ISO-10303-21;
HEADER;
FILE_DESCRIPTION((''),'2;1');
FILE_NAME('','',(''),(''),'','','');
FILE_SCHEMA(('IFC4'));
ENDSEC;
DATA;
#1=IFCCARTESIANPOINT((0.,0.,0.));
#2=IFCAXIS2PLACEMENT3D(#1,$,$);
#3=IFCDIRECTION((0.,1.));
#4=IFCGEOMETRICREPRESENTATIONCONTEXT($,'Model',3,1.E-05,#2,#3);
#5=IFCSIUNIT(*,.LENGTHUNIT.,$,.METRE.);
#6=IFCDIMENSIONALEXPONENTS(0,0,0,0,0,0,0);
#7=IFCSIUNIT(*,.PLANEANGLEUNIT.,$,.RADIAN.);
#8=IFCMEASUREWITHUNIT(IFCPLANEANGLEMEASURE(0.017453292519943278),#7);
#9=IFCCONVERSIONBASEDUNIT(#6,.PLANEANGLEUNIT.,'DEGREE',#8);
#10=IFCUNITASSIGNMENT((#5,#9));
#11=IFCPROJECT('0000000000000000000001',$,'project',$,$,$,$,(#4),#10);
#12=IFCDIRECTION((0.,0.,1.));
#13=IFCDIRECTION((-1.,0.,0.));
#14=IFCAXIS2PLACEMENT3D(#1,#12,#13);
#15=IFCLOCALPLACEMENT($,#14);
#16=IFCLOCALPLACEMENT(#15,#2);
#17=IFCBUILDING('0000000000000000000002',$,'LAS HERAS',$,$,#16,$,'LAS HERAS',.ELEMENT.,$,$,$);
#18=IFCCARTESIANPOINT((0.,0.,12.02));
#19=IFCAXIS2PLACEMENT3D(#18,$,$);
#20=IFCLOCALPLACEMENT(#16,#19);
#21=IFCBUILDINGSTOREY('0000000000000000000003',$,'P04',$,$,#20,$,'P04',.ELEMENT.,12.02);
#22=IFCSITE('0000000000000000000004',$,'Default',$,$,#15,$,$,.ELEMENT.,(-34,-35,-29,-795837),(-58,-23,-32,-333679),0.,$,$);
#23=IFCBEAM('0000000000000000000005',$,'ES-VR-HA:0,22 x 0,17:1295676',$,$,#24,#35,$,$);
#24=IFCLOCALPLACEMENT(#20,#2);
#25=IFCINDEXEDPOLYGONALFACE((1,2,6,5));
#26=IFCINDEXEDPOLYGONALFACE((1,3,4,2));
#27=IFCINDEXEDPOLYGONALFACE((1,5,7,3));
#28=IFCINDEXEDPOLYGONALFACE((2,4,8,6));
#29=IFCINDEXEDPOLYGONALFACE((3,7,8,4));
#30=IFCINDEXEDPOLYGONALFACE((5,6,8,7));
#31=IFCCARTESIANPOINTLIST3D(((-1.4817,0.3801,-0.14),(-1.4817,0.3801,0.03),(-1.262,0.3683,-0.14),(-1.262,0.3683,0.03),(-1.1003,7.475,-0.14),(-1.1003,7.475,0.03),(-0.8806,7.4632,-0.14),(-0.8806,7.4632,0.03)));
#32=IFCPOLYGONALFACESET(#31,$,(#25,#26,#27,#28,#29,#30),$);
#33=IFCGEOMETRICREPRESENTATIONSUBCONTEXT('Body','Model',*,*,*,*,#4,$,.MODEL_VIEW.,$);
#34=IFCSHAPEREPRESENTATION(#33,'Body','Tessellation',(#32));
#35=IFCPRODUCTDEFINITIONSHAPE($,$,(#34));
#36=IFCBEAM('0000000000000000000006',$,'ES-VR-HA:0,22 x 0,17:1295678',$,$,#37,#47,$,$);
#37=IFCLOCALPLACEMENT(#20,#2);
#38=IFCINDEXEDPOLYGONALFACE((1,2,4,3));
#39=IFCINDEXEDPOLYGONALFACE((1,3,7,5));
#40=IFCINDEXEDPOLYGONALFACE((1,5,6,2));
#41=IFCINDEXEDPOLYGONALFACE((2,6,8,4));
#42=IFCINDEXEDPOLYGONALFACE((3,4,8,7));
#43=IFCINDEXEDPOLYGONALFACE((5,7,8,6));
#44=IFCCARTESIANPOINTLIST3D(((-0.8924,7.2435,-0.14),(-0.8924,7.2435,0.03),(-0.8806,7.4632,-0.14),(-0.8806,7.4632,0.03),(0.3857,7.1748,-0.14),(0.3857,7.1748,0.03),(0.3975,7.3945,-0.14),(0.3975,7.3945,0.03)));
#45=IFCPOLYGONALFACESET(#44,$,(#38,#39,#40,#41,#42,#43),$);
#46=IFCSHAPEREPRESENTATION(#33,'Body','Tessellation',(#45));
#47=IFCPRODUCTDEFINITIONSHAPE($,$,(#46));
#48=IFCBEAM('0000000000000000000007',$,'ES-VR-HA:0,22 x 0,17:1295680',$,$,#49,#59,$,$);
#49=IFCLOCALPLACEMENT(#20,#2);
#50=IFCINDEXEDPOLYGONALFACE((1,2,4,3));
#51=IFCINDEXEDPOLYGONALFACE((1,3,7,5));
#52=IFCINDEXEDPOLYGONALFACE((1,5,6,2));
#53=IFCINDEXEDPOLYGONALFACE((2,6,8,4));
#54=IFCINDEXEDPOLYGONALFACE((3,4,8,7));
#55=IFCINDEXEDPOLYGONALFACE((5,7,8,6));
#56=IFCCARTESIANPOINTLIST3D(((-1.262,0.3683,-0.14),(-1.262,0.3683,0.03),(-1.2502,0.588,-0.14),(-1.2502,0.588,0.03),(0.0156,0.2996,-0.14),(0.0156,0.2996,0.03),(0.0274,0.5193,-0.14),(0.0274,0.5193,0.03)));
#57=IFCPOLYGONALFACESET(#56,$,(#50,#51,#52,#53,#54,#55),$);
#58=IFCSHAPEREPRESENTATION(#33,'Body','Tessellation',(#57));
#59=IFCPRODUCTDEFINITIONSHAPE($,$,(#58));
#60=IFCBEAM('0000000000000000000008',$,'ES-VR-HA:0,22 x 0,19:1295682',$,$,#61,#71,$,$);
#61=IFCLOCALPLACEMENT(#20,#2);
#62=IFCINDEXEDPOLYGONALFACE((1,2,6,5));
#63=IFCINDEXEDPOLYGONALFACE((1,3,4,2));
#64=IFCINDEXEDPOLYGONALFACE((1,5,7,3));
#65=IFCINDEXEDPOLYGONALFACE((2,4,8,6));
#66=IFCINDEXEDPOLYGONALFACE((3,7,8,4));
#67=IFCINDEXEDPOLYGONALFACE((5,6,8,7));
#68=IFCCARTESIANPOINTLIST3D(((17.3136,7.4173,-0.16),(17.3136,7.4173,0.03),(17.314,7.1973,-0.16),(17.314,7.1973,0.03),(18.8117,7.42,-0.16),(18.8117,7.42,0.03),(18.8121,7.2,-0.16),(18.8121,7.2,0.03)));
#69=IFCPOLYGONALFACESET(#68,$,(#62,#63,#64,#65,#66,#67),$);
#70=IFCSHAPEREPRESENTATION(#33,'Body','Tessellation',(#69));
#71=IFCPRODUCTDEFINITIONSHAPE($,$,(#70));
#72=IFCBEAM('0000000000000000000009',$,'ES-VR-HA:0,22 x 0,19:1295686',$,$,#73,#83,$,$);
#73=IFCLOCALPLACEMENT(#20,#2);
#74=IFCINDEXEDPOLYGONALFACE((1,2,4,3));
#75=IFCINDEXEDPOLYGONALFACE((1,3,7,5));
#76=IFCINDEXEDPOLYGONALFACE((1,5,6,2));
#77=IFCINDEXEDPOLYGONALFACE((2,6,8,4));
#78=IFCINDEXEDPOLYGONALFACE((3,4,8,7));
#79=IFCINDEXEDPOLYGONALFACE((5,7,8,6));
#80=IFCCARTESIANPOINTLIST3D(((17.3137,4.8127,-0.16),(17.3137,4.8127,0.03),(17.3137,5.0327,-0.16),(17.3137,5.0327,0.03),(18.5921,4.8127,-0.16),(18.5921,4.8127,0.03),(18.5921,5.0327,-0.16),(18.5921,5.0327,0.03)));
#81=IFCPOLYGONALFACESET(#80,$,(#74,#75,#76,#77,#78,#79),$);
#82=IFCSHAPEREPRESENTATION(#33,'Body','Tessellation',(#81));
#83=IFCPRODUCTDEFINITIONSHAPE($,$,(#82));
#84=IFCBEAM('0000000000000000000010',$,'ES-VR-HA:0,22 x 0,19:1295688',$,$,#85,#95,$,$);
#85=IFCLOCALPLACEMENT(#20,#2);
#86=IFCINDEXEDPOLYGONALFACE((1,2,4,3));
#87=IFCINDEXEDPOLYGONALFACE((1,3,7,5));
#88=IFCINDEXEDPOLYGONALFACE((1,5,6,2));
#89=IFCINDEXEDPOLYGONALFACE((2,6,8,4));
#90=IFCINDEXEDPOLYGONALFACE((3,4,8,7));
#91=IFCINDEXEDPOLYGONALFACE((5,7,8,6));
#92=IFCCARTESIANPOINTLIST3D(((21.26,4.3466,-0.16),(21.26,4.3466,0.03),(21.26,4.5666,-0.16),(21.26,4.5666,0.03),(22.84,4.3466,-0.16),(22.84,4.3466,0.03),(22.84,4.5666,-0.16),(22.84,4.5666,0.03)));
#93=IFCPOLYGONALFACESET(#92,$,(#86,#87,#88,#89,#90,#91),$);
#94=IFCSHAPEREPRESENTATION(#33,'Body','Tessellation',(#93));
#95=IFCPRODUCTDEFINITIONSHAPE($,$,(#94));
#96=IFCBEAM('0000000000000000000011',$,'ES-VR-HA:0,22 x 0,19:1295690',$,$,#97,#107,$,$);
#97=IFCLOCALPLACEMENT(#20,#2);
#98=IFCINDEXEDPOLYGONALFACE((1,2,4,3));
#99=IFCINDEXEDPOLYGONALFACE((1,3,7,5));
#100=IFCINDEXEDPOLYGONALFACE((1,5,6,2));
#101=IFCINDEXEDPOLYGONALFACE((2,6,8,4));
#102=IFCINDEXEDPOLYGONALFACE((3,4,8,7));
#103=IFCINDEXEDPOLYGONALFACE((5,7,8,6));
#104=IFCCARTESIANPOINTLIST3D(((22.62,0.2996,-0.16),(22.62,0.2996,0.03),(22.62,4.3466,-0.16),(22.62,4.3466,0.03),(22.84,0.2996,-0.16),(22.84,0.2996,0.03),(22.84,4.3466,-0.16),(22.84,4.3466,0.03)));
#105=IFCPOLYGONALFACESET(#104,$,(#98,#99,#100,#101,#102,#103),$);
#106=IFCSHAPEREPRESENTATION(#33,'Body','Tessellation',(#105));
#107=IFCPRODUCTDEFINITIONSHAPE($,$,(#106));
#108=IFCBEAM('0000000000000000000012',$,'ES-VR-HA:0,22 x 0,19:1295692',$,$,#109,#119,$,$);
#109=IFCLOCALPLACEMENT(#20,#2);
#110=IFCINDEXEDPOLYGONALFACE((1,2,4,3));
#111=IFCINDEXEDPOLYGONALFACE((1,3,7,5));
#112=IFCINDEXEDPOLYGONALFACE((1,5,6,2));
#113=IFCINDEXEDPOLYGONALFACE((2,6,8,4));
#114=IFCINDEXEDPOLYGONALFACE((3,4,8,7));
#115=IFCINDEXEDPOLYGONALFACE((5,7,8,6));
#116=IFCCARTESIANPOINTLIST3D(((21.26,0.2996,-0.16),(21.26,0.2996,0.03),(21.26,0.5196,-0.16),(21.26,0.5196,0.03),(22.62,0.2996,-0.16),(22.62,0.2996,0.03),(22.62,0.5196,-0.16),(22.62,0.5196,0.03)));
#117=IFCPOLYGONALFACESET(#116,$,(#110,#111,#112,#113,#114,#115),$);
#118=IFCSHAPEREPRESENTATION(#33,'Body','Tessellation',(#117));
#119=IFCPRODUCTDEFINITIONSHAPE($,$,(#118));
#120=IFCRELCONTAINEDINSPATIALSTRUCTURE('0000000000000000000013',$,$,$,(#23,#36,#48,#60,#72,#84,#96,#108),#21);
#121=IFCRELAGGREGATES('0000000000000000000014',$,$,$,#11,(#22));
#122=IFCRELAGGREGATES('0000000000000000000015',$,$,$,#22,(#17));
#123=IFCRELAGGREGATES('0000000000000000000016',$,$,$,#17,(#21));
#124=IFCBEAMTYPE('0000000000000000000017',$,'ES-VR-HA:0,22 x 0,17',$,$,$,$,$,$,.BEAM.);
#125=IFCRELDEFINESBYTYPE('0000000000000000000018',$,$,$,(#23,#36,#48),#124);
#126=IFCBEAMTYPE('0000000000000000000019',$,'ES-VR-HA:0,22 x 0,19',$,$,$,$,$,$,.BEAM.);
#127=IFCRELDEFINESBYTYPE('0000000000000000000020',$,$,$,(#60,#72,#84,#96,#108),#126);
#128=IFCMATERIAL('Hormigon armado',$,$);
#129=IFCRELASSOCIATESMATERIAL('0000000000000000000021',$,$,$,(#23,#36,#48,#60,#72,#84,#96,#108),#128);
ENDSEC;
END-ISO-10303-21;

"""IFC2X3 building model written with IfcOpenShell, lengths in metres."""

from ifc_helpers import new_model, entity, si_unit, converted_unit, direction, frame, frame_2d, origin, place, context, subcontext, project, spatial, rectangle, extrude, material, type_object, element, save


model = new_model("IFC2X3")

# Units and contexts
model_context = context("Model", 3, precision=1e-05, world=origin(), true_north=direction((0.0, 1.0)))
body_context = subcontext(model_context, "Body", "Model", "MODEL_VIEW")
ifc_project = project(units=[si_unit("LENGTHUNIT", "METRE"), converted_unit("PLANEANGLEUNIT", "DEGREE", entity("IfcPlaneAngleMeasure", 0.017453292519943278), si_unit("PLANEANGLEUNIT", "RADIAN"), dimensions=[0, 0, 0, 0, 0, 0, 0])], contexts=[model_context])

# Site, building, storey
site_placement = place(None, frame((0.0, 0.0, 0.0), z_axis=(0.0, 0.0, 1.0), x_axis=(-1.0, 0.0, 0.0)))
site = spatial("IfcSite", under=ifc_project, at=site_placement, Name="Default", CompositionType="ELEMENT", RefLatitude=(-34, -35, -29, -795837), RefLongitude=(-58, -23, -32, -333679), RefElevation=0.0)
building_placement = place(site_placement, origin())
building = spatial("IfcBuilding", under=site, at=building_placement, Name="LAS HERAS", LongName="LAS HERAS", CompositionType="ELEMENT")
storey_placement = place(building_placement, frame((0.0, 0.0, 12.02)))
storey = spatial("IfcBuildingStorey", under=building, at=storey_placement, Name="P04", LongName="P04", CompositionType="ELEMENT", Elevation=12.02)

# Beams
ifc_material = material(Name="Hormigon armado")
beam_type_1 = type_object("IfcBeamType", Name="ES-VR-HA:0,22 x 0,17", PredefinedType="BEAM")
beam_1_placement = place(storey_placement, frame((-0.9963, 7.3593, 0.03), z_axis=(0.0, 0.0, 1.0), x_axis=(-0.05369, -0.998558, 0.0)))
element("IfcBeam", 1, at=beam_1_placement, inside=storey, type_object=beam_type_1, material=ifc_material, Name="ES-VR-HA:0,22 x 0,17:1295676", context=body_context, shape_type="SweptSolid", body=[
    extrude(rectangle(XDim=0.17, YDim=0.22, at=frame_2d((0.0, 0.0), x_axis=(1.0, 0.0))), frame((-0.11, 0.0, -0.085), z_axis=(1.0, 0.0, 0.0), x_axis=(0.0, 0.0, -1.0)), (0.0, 0.0, 1.0), 7.1052),
])
beam_2_placement = place(storey_placement, frame((0.3916, 7.2846, 0.03), z_axis=(0.0, 0.0, 1.0), x_axis=(-0.998558, 0.05368, 0.0)))
element("IfcBeam", 2, at=beam_2_placement, inside=storey, type_object=beam_type_1, material=ifc_material, Name="ES-VR-HA:0,22 x 0,17:1295678", context=body_context, shape_type="SweptSolid", body=[
    extrude(rectangle(XDim=0.17, YDim=0.22, at=frame_2d((0.0, 0.0), x_axis=(1.0, 0.0))), frame((0.0, 0.0, -0.085), z_axis=(1.0, 0.0, 0.0), x_axis=(0.0, 0.0, -1.0)), (0.0, 0.0, 1.0), 1.28),
])
beam_3_placement = place(storey_placement, frame((0.0215, 0.4094, 0.03), z_axis=(0.0, 0.0, 1.0), x_axis=(-0.998558, 0.05369, 0.0)))
element("IfcBeam", 3, at=beam_3_placement, inside=storey, type_object=beam_type_1, material=ifc_material, Name="ES-VR-HA:0,22 x 0,17:1295680", context=body_context, shape_type="SweptSolid", body=[
    extrude(rectangle(XDim=0.17, YDim=0.22, at=frame_2d((0.0, 0.0), x_axis=(1.0, 0.0))), frame((0.0, 0.0, -0.085), z_axis=(1.0, 0.0, 0.0), x_axis=(0.0, 0.0, -1.0)), (0.0, 0.0, 1.0), 1.2795),
])
beam_type_2 = type_object("IfcBeamType", Name="ES-VR-HA:0,22 x 0,19", PredefinedType="BEAM")
beam_4_placement = place(storey_placement, frame((17.3138, 7.3073, 0.03), z_axis=(0.0, 0.0, 1.0), x_axis=(0.999998, 0.001781, 0.0)))
element("IfcBeam", 4, at=beam_4_placement, inside=storey, type_object=beam_type_2, material=ifc_material, Name="ES-VR-HA:0,22 x 0,19:1295682", context=body_context, shape_type="SweptSolid", body=[
    extrude(rectangle(XDim=0.19, YDim=0.22, at=frame_2d((0.0, 0.0), x_axis=(1.0, 0.0))), frame((0.0, 0.0, -0.095), z_axis=(1.0, 0.0, 0.0), x_axis=(0.0, 0.0, -1.0)), (0.0, 0.0, 1.0), 1.4981),
])
beam_5_placement = place(storey_placement, frame((17.3137, 4.9227, 0.03)))
element("IfcBeam", 5, at=beam_5_placement, inside=storey, type_object=beam_type_2, material=ifc_material, Name="ES-VR-HA:0,22 x 0,19:1295686", context=body_context, shape_type="SweptSolid", body=[
    extrude(rectangle(XDim=0.19, YDim=0.22, at=frame_2d((0.0, 0.0), x_axis=(1.0, 0.0))), frame((0.0, 0.0, -0.095), z_axis=(1.0, 0.0, 0.0), x_axis=(0.0, 0.0, -1.0)), (0.0, 0.0, 1.0), 1.2784),
])
beam_6_placement = place(storey_placement, frame((21.26, 4.4566, 0.03)))
element("IfcBeam", 6, at=beam_6_placement, inside=storey, type_object=beam_type_2, material=ifc_material, Name="ES-VR-HA:0,22 x 0,19:1295688", context=body_context, shape_type="SweptSolid", body=[
    extrude(rectangle(XDim=0.19, YDim=0.22, at=frame_2d((0.0, 0.0), x_axis=(1.0, 0.0))), frame((0.0, 0.0, -0.095), z_axis=(1.0, 0.0, 0.0), x_axis=(0.0, 0.0, -1.0)), (0.0, 0.0, 1.0), 1.58),
])
beam_7_placement = place(storey_placement, frame((22.73, 4.4566, 0.03), z_axis=(0.0, 0.0, 1.0), x_axis=(0.0, -1.0, 0.0)))
element("IfcBeam", 7, at=beam_7_placement, inside=storey, type_object=beam_type_2, material=ifc_material, Name="ES-VR-HA:0,22 x 0,19:1295690", context=body_context, shape_type="SweptSolid", body=[
    extrude(rectangle(XDim=0.19, YDim=0.22, at=frame_2d((0.0, 0.0), x_axis=(1.0, 0.0))), frame((0.11, 0.0, -0.095), z_axis=(1.0, 0.0, 0.0), x_axis=(0.0, 0.0, -1.0)), (0.0, 0.0, 1.0), 4.0471),
])
beam_8_placement = place(storey_placement, frame((21.26, 0.4096, 0.03)))
element("IfcBeam", 8, at=beam_8_placement, inside=storey, type_object=beam_type_2, material=ifc_material, Name="ES-VR-HA:0,22 x 0,19:1295692", context=body_context, shape_type="SweptSolid", body=[
    extrude(rectangle(XDim=0.19, YDim=0.22, at=frame_2d((0.0, 0.0), x_axis=(1.0, 0.0))), frame((0.0, 0.0, -0.095), z_axis=(1.0, 0.0, 0.0), x_axis=(0.0, 0.0, -1.0)), (0.0, 0.0, 1.0), 1.36),
])

save(model, "model.ifc")
